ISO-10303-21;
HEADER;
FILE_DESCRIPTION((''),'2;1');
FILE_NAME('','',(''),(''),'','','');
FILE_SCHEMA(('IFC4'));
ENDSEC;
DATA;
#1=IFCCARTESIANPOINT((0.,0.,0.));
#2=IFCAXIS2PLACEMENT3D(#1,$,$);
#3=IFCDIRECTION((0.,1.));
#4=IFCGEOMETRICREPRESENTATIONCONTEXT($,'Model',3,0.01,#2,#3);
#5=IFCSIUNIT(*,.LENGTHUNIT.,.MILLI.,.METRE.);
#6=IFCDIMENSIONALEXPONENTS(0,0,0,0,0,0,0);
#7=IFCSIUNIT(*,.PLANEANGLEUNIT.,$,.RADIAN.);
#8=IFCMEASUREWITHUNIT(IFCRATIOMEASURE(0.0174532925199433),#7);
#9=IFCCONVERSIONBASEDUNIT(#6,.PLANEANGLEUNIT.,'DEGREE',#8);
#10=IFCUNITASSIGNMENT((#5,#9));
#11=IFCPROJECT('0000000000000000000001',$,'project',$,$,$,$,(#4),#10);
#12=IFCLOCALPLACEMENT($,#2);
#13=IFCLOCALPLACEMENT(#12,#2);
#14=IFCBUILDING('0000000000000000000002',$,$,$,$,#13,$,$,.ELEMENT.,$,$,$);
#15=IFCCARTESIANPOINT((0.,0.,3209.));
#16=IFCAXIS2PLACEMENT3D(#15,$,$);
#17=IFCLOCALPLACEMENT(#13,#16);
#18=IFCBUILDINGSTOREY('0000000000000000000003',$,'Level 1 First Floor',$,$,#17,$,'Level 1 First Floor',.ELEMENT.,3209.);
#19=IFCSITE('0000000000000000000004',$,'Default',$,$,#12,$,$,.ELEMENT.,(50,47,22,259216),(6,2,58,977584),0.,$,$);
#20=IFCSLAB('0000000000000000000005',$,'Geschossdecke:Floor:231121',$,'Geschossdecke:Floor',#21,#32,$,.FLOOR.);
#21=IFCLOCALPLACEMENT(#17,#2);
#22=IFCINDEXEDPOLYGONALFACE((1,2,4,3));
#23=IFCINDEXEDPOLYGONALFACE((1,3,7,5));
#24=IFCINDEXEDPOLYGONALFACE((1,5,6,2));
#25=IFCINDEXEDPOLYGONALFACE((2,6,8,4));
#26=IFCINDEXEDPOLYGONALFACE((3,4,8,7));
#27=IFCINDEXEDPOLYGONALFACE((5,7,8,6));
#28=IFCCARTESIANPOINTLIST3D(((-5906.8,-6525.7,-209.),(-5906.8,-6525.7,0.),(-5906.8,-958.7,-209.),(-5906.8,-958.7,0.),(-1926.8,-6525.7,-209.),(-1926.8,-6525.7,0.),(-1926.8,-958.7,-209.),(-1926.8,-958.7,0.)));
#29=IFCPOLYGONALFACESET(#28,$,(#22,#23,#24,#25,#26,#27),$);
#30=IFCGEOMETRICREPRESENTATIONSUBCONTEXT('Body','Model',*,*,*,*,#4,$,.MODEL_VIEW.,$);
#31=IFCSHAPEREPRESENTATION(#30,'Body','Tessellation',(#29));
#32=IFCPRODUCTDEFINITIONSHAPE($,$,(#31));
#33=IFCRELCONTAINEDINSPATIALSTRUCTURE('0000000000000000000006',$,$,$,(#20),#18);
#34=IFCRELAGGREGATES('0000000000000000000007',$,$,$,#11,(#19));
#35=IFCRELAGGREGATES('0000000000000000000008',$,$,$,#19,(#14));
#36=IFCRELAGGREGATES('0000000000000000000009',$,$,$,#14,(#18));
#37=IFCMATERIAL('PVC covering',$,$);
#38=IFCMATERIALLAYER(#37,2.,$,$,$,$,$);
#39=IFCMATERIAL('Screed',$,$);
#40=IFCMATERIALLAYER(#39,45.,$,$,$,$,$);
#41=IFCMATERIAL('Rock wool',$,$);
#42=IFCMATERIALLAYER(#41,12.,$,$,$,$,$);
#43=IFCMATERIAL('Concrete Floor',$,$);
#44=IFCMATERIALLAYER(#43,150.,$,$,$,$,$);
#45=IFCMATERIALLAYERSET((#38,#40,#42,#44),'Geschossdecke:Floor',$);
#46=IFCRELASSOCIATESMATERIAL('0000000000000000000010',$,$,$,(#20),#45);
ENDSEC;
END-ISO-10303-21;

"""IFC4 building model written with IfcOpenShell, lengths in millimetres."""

from ifc_helpers import new_model, entity, si_unit, converted_unit, direction, frame, frame_2d, origin, place, context, subcontext, project, spatial, rectangle, extrude, material, layer, layer_set, layer_usage, element, save


model = new_model("IFC4")

# Units and contexts
model_context = context("Model", 3, precision=0.01, world=origin(), true_north=direction((0.0, 1.0)))
body_context = subcontext(model_context, "Body", "Model", "MODEL_VIEW")
ifc_project = project(units=[si_unit("LENGTHUNIT", "METRE", prefix="MILLI"), converted_unit("PLANEANGLEUNIT", "DEGREE", entity("IfcRatioMeasure", 0.0174532925199433), si_unit("PLANEANGLEUNIT", "RADIAN"), dimensions=[0, 0, 0, 0, 0, 0, 0])], contexts=[model_context])

# Site, building, storey
site_placement = place(None, origin())
site = spatial("IfcSite", under=ifc_project, at=site_placement, Name="Default", CompositionType="ELEMENT", RefLatitude=(50, 47, 22, 259216), RefLongitude=(6, 2, 58, 977584), RefElevation=0.0)
building_placement = place(site_placement, origin())
building = spatial("IfcBuilding", under=site, at=building_placement, CompositionType="ELEMENT")
storey_placement = place(building_placement, frame((0.0, 0.0, 3209.0)))
storey = spatial("IfcBuildingStorey", under=building, at=storey_placement, Name="Level 1 First Floor", LongName="Level 1 First Floor", CompositionType="ELEMENT", Elevation=3209.0)

# Slab
ifc_material_1 = material(Name="PVC covering")
ifc_layer_1 = layer(ifc_material_1, 2.0)
ifc_material_2 = material(Name="Screed")
ifc_layer_2 = layer(ifc_material_2, 45.0)
ifc_material_3 = material(Name="Rock wool")
ifc_layer_3 = layer(ifc_material_3, 12.0)
ifc_material_4 = material(Name="Concrete Floor")
ifc_layer_4 = layer(ifc_material_4, 150.0)
ifc_layer_set = layer_set([ifc_layer_1, ifc_layer_2, ifc_layer_3, ifc_layer_4], Name="Geschossdecke:Floor")
ifc_layer_usage = layer_usage(ifc_layer_set, "AXIS3", "POSITIVE", 0.0)
slab_placement = place(storey_placement, origin())
element("IfcSlab", 1, at=slab_placement, inside=storey, material=ifc_layer_usage, Name="Geschossdecke:Floor:231121", ObjectType="Geschossdecke:Floor", PredefinedType="FLOOR", context=body_context, shape_type="SweptSolid", body=[
    extrude(rectangle(XDim=5567.0, YDim=3980.0, at=frame_2d((0.0, 0.0), x_axis=(1.0, 0.0))), frame((-3916.8, -3742.2, 0.0), z_axis=(0.0, 0.0, -1.0), x_axis=(0.0, 1.0, 0.0)), (0.0, 0.0, 1.0), 209.0),
])

save(model, "model.ifc")
